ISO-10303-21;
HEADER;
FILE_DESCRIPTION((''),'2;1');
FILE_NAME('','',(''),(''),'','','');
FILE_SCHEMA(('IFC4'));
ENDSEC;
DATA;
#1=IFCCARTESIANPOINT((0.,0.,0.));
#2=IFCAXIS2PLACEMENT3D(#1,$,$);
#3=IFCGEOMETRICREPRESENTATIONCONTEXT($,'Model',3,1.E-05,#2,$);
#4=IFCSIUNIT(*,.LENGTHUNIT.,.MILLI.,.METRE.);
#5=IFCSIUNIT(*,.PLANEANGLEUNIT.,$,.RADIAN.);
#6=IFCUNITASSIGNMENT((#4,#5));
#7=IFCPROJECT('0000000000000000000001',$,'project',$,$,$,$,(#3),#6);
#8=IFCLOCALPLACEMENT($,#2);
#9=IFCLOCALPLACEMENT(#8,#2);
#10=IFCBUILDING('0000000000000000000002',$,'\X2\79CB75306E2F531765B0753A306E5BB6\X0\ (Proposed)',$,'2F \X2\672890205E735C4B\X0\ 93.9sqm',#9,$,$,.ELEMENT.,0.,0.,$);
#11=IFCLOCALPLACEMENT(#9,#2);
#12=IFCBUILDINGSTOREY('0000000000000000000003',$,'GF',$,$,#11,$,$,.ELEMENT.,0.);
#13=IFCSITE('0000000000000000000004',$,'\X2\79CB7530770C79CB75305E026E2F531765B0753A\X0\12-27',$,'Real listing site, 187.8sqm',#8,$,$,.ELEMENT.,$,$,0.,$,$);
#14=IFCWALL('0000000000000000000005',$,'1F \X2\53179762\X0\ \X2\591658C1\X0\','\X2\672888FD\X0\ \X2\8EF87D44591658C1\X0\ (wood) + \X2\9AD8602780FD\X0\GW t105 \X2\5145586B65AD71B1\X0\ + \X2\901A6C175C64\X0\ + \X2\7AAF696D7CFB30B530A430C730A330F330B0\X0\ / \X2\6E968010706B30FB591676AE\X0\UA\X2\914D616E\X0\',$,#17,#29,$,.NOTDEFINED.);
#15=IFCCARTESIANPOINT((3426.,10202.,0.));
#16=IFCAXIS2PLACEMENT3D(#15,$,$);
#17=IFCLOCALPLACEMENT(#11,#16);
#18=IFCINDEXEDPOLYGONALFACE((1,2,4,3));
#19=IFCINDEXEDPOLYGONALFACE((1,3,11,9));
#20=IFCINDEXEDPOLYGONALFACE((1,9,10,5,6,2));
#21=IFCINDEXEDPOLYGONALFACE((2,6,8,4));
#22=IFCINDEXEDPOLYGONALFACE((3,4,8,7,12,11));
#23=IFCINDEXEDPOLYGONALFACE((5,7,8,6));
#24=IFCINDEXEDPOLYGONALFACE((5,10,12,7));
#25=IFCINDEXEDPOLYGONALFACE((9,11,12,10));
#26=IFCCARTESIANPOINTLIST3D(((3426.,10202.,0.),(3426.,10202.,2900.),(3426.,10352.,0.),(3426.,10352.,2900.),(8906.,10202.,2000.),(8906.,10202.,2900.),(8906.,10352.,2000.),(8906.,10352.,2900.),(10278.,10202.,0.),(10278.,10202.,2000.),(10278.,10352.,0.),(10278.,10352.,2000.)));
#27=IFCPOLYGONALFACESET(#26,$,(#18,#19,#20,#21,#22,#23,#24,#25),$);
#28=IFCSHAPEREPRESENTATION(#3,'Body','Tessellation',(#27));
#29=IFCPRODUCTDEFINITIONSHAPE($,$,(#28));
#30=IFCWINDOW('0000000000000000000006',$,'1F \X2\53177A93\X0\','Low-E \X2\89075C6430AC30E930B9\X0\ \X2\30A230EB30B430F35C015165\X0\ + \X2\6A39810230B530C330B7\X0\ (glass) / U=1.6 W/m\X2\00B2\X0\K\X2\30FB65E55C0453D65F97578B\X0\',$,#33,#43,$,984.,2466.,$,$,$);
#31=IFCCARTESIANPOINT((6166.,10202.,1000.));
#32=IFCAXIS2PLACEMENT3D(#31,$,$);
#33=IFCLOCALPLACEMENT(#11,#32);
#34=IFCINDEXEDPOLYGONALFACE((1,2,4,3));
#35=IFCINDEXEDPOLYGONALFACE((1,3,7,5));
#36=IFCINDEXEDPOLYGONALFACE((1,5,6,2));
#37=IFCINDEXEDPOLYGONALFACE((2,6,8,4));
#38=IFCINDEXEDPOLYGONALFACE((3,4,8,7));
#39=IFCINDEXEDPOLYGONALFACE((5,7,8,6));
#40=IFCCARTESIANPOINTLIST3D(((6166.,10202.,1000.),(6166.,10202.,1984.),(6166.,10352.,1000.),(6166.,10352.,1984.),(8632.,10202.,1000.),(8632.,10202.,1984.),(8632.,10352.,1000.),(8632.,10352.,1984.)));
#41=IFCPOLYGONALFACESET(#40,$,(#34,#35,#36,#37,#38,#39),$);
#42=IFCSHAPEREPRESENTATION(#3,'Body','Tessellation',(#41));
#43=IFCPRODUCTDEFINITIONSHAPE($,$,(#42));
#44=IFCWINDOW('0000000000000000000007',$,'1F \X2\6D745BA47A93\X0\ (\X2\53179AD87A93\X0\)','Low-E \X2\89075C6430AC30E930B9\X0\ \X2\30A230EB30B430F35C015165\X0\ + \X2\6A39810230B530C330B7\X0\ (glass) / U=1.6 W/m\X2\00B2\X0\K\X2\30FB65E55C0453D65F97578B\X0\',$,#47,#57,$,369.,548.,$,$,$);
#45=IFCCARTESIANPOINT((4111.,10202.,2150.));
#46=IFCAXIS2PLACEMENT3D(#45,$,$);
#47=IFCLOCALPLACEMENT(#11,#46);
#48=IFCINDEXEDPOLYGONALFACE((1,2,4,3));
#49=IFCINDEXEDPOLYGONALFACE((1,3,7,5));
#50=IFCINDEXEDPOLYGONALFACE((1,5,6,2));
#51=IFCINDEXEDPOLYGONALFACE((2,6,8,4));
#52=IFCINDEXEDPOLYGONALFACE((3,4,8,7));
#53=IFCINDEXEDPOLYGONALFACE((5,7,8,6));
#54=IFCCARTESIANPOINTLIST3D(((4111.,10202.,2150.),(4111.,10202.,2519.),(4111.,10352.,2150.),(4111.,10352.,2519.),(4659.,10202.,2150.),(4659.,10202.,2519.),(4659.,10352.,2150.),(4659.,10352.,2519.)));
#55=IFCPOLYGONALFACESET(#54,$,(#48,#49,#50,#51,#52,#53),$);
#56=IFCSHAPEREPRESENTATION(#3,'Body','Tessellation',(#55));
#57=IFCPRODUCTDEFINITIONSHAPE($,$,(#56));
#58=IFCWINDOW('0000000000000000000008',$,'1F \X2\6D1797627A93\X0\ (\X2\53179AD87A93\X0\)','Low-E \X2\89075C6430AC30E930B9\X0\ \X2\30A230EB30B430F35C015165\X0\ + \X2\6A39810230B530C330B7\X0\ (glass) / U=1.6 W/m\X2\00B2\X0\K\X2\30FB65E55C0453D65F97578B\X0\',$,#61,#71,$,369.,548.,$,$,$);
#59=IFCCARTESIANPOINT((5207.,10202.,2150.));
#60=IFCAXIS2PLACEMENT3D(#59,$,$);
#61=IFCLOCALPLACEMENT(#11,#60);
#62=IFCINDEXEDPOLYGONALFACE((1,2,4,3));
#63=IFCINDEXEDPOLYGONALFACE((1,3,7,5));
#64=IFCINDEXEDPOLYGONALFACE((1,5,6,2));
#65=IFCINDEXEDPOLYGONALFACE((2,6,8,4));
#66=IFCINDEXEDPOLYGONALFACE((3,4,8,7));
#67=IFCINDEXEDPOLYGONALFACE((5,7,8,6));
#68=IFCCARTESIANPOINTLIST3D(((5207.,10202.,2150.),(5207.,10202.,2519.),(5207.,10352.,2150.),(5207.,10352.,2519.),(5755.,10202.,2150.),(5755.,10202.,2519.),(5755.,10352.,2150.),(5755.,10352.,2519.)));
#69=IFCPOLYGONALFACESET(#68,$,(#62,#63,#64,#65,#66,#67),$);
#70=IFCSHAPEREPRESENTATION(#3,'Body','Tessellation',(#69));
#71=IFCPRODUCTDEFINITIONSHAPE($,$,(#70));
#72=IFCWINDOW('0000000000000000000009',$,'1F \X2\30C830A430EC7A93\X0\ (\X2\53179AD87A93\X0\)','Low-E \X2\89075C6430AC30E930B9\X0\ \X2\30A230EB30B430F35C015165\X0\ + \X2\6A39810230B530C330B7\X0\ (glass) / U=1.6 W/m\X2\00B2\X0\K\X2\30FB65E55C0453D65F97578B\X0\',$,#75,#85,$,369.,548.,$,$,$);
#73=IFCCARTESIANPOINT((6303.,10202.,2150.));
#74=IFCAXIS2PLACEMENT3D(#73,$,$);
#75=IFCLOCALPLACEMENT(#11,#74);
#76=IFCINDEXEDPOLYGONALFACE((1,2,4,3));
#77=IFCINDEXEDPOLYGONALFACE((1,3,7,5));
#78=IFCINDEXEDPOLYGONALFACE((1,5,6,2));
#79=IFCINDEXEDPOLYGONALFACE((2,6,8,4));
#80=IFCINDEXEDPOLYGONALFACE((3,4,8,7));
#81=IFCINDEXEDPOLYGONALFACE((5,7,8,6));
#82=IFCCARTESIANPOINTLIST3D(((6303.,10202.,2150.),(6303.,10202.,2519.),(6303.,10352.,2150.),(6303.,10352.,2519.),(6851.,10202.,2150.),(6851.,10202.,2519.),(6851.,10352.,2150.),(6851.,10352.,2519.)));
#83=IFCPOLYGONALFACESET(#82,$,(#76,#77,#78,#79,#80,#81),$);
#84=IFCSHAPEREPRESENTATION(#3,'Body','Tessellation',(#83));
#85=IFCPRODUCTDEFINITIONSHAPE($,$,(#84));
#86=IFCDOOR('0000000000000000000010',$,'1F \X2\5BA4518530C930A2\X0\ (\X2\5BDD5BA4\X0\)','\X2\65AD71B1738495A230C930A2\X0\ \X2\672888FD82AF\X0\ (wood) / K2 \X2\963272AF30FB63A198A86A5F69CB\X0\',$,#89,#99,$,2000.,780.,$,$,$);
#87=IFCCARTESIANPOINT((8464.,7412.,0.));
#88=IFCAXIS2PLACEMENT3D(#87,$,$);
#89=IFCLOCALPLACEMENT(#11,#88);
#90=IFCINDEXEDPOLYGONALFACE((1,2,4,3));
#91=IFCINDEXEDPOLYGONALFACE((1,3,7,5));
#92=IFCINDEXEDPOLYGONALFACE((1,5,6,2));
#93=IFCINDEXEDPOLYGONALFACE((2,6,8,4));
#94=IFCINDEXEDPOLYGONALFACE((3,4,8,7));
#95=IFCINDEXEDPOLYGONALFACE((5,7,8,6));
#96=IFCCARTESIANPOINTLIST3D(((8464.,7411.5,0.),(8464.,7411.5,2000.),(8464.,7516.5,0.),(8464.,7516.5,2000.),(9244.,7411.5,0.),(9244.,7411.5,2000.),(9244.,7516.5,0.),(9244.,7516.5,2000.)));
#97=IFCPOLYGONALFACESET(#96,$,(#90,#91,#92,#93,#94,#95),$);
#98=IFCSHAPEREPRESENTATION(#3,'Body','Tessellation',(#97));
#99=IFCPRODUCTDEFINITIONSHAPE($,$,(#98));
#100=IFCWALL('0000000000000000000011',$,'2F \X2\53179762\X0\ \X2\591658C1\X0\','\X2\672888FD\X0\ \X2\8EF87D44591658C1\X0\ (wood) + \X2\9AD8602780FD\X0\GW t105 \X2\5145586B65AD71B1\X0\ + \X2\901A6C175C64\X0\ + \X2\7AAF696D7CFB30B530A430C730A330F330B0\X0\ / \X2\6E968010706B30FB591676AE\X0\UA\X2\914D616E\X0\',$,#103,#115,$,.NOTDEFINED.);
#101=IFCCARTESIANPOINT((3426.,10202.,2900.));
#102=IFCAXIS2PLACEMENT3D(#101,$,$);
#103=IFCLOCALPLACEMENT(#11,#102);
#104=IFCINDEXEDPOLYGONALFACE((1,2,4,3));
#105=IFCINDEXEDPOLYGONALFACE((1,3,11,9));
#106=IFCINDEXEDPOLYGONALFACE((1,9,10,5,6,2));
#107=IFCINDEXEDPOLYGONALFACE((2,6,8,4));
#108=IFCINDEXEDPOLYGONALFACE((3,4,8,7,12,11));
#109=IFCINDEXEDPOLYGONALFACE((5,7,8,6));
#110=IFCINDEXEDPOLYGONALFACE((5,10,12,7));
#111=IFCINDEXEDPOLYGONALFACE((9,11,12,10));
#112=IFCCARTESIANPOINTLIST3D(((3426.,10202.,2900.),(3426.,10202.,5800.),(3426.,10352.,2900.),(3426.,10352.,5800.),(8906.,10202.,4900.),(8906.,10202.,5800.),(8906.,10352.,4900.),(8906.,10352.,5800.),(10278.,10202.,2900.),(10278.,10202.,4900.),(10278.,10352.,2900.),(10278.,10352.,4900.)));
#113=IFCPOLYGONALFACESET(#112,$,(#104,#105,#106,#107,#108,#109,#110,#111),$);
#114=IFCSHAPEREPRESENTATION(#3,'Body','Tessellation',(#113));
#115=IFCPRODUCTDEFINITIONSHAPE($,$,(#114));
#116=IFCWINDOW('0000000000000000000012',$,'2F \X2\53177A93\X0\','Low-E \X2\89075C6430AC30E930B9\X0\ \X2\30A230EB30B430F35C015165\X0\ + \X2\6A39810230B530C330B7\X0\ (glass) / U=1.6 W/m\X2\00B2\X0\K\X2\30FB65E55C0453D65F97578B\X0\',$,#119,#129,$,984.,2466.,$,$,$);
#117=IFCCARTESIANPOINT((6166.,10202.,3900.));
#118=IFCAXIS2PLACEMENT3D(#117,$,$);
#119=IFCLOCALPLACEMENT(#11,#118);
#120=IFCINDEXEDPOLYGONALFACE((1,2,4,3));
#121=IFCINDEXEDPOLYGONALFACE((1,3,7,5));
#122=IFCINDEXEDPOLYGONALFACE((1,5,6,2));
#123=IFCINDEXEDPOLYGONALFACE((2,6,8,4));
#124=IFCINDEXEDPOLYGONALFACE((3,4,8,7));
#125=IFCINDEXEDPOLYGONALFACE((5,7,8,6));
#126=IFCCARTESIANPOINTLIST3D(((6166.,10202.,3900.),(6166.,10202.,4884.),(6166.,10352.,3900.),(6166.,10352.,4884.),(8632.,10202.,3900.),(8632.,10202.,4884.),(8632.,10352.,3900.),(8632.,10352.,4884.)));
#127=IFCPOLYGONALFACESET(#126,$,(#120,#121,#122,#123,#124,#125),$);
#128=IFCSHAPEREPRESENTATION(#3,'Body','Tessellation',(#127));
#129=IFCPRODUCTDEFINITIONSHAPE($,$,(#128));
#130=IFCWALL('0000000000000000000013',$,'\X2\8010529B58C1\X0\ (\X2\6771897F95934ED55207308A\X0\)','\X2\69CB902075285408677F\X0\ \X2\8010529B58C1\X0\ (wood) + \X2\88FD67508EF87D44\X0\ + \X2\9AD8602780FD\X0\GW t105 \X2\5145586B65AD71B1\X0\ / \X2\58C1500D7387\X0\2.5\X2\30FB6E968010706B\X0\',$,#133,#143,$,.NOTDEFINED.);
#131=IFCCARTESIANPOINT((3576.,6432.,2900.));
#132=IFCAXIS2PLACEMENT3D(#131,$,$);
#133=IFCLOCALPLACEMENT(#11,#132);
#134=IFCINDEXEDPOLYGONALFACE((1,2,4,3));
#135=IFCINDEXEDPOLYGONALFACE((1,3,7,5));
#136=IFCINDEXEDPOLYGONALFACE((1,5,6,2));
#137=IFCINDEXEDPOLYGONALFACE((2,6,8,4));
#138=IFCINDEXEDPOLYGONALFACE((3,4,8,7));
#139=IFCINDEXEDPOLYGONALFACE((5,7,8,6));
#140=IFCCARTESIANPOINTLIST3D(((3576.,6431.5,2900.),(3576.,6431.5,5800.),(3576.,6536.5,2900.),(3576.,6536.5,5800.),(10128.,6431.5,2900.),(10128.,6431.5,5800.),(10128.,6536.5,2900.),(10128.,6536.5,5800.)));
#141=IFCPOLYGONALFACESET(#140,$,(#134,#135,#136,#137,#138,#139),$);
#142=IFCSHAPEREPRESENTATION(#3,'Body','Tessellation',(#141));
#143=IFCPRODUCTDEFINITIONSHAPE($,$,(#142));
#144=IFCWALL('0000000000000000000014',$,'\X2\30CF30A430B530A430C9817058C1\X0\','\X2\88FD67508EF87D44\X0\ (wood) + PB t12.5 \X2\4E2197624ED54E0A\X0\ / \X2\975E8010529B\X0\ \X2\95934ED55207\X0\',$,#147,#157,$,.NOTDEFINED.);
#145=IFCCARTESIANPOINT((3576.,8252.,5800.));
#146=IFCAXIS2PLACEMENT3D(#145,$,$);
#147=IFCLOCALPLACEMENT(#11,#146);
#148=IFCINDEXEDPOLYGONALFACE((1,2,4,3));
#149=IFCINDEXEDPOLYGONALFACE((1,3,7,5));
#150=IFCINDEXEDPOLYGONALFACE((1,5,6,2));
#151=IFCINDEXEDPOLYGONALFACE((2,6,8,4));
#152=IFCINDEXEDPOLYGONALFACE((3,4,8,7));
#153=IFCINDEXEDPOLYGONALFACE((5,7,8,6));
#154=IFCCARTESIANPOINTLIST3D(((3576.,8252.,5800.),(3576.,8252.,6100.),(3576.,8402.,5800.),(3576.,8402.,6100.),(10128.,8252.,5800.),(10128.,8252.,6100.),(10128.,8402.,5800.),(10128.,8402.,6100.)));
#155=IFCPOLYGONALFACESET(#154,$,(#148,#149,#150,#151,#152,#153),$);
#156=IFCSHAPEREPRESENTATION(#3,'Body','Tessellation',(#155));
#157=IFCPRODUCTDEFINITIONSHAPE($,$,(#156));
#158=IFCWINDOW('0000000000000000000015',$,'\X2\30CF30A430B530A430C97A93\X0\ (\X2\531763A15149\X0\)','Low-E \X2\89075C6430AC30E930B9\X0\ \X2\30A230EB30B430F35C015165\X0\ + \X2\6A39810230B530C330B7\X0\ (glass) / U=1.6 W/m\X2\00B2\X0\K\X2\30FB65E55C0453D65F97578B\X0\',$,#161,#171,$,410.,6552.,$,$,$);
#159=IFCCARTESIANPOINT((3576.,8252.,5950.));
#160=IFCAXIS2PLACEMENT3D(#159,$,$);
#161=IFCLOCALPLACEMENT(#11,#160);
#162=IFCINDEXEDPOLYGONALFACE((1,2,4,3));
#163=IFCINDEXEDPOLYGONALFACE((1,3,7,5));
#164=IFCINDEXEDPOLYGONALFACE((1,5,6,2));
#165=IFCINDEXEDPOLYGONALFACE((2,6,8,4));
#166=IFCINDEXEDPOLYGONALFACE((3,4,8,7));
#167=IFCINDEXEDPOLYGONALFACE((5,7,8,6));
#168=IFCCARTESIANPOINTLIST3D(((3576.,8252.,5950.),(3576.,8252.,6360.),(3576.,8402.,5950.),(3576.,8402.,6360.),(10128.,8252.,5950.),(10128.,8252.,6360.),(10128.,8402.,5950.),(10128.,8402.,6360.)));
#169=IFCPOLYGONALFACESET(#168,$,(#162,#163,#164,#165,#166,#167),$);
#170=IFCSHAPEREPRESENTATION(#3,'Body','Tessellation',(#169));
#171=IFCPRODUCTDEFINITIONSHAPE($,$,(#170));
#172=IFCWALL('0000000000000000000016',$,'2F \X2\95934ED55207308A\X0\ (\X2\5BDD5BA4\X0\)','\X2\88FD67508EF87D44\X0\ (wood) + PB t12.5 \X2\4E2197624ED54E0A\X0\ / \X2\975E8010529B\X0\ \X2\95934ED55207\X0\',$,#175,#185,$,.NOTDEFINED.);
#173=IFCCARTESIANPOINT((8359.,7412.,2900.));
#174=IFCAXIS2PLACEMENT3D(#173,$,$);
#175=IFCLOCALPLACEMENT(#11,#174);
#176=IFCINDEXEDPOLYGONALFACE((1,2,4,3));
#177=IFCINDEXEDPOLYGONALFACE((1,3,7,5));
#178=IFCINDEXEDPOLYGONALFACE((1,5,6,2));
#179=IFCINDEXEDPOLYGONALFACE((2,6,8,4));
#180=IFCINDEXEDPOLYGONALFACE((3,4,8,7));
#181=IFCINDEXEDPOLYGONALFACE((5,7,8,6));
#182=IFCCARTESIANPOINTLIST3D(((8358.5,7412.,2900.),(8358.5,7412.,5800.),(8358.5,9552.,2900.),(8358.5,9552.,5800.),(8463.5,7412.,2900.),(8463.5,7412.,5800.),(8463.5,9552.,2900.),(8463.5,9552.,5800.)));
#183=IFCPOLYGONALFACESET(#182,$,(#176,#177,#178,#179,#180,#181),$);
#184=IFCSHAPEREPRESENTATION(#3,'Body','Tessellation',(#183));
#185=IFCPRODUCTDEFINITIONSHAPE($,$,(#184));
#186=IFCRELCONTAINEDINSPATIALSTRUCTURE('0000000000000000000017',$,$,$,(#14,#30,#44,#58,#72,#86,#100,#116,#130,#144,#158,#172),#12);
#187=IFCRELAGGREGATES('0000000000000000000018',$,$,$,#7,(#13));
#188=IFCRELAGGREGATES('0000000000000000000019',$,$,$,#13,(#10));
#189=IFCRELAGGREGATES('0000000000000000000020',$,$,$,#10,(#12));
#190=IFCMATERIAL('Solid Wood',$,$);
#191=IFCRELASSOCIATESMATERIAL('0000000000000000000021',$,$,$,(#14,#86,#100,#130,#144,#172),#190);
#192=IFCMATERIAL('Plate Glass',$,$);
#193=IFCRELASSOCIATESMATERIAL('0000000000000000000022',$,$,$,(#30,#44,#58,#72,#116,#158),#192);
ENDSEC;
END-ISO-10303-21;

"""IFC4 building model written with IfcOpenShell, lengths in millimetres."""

from ifc_helpers import new_model, si_unit, frame, frame_2d, origin, place, context, project, spatial, rectangle, extrude, material, element, fill, save


model = new_model("IFC4")

# Units and contexts
model_context = context("Model", 3, precision=1e-05, world=origin())
ifc_project = project(units=[si_unit("LENGTHUNIT", "METRE", prefix="MILLI"), si_unit("PLANEANGLEUNIT", "RADIAN")], contexts=[model_context])

# Site, building, storey
site_placement = place(None, origin())
site = spatial("IfcSite", under=ifc_project, at=site_placement, Name="秋田県秋田市港北新町12-27", ObjectType="Real listing site, 187.8sqm", CompositionType="ELEMENT", RefElevation=0.0)
building_placement = place(site_placement, origin())
building = spatial("IfcBuilding", under=site, at=building_placement, Name="秋田港北新町の家 (Proposed)", ObjectType="2F 木造平屋 93.9sqm", CompositionType="ELEMENT", ElevationOfRefHeight=0.0, ElevationOfTerrain=0.0)
storey_placement = place(building_placement, origin())
storey = spatial("IfcBuildingStorey", under=building, at=storey_placement, Name="GF", CompositionType="ELEMENT", Elevation=0.0)

# Wall, openings, windows
ifc_material_1 = material(Name="Solid Wood")
wall_1_placement = place(storey_placement, frame((3426.0, 10202.0, 0.0)))
wall_1 = element("IfcWall", 1, at=wall_1_placement, inside=storey, material=ifc_material_1, Name="1F 北面 外壁", Description="木製 軸組外壁 (wood) + 高性能GW t105 充填断熱 + 通気層 + 窯業系サイディング / 準耐火・外皮UA配慮", PredefinedType="NOTDEFINED", context=model_context, shape_type="SweptSolid", body=[
    extrude(rectangle(XDim=6852.0, YDim=150.0, at=frame_2d((3426.0, 75.0))), frame((3426.0, 10202.0, 0.0)), (0.0, 0.0, 1.0), 2900.0),
])
opening_1_placement = place(storey_placement, frame((6166.0, 10202.0, 1000.0)))
opening_1 = element("IfcOpeningElement", 2, at=opening_1_placement, cuts=wall_1, PredefinedType="NOTDEFINED", context=model_context, shape_type="SweptSolid", body=[
    extrude(rectangle(XDim=2466.0, YDim=150.0, at=frame_2d((1233.0, 75.0))), frame((6166.0, 10202.0, 1000.0)), (0.0, 0.0, 1.0), 984.0),
])
opening_2_placement = place(storey_placement, frame((4111.0, 10202.0, 2150.0)))
opening_2 = element("IfcOpeningElement", 3, at=opening_2_placement, cuts=wall_1, PredefinedType="NOTDEFINED", context=model_context, shape_type="SweptSolid", body=[
    extrude(rectangle(XDim=548.0, YDim=150.0, at=frame_2d((274.0, 75.0))), frame((4111.0, 10202.0, 2150.0)), (0.0, 0.0, 1.0), 369.0),
])
opening_3_placement = place(storey_placement, frame((5207.0, 10202.0, 2150.0)))
opening_3 = element("IfcOpeningElement", 4, at=opening_3_placement, cuts=wall_1, PredefinedType="NOTDEFINED", context=model_context, shape_type="SweptSolid", body=[
    extrude(rectangle(XDim=548.0, YDim=150.0, at=frame_2d((274.0, 75.0))), frame((5207.0, 10202.0, 2150.0)), (0.0, 0.0, 1.0), 369.0),
])
opening_4_placement = place(storey_placement, frame((6303.0, 10202.0, 2150.0)))
opening_4 = element("IfcOpeningElement", 5, at=opening_4_placement, cuts=wall_1, PredefinedType="NOTDEFINED", context=model_context, shape_type="SweptSolid", body=[
    extrude(rectangle(XDim=548.0, YDim=150.0, at=frame_2d((274.0, 75.0))), frame((6303.0, 10202.0, 2150.0)), (0.0, 0.0, 1.0), 369.0),
])
ifc_material_2 = material(Name="Plate Glass")
window_1_placement = place(storey_placement, frame((6166.0, 10202.0, 1000.0)))
window_1 = element("IfcWindow", 6, at=window_1_placement, inside=storey, material=ifc_material_2, Name="1F 北窓", Description="Low-E 複層ガラス アルゴン封入 + 樹脂サッシ (glass) / U=1.6 W/m²K・日射取得型", OverallHeight=984.0, OverallWidth=2466.0, context=model_context, shape_type="SweptSolid", body=[
    extrude(rectangle(XDim=2466.0, YDim=150.0, at=frame_2d((1233.0, 75.0))), frame((6166.0, 10202.0, 1000.0)), (0.0, 0.0, 1.0), 984.0),
])
fill(opening_1, window_1)
window_2_placement = place(storey_placement, frame((4111.0, 10202.0, 2150.0)))
window_2 = element("IfcWindow", 7, at=window_2_placement, inside=storey, material=ifc_material_2, Name="1F 浴室窓 (北高窓)", Description="Low-E 複層ガラス アルゴン封入 + 樹脂サッシ (glass) / U=1.6 W/m²K・日射取得型", OverallHeight=369.0, OverallWidth=548.0, context=model_context, shape_type="SweptSolid", body=[
    extrude(rectangle(XDim=548.0, YDim=150.0, at=frame_2d((274.0, 75.0))), frame((4111.0, 10202.0, 2150.0)), (0.0, 0.0, 1.0), 369.0),
])
fill(opening_2, window_2)
window_3_placement = place(storey_placement, frame((5207.0, 10202.0, 2150.0)))
window_3 = element("IfcWindow", 8, at=window_3_placement, inside=storey, material=ifc_material_2, Name="1F 洗面窓 (北高窓)", Description="Low-E 複層ガラス アルゴン封入 + 樹脂サッシ (glass) / U=1.6 W/m²K・日射取得型", OverallHeight=369.0, OverallWidth=548.0, context=model_context, shape_type="SweptSolid", body=[
    extrude(rectangle(XDim=548.0, YDim=150.0, at=frame_2d((274.0, 75.0))), frame((5207.0, 10202.0, 2150.0)), (0.0, 0.0, 1.0), 369.0),
])
fill(opening_3, window_3)
window_4_placement = place(storey_placement, frame((6303.0, 10202.0, 2150.0)))
window_4 = element("IfcWindow", 9, at=window_4_placement, inside=storey, material=ifc_material_2, Name="1F トイレ窓 (北高窓)", Description="Low-E 複層ガラス アルゴン封入 + 樹脂サッシ (glass) / U=1.6 W/m²K・日射取得型", OverallHeight=369.0, OverallWidth=548.0, context=model_context, shape_type="SweptSolid", body=[
    extrude(rectangle(XDim=548.0, YDim=150.0, at=frame_2d((274.0, 75.0))), frame((6303.0, 10202.0, 2150.0)), (0.0, 0.0, 1.0), 369.0),
])
fill(opening_4, window_4)

# Door
door_1_placement = place(storey_placement, frame((8464.0, 7412.0, 0.0)))
element("IfcDoor", 10, at=door_1_placement, inside=storey, material=ifc_material_1, Name="1F 室内ドア (寝室)", Description="断熱玄関ドア 木製芯 (wood) / K2 防犯・採風機構", OverallHeight=2000.0, OverallWidth=780.0, context=model_context, shape_type="SweptSolid", body=[
    extrude(rectangle(XDim=780.0, YDim=105.0, at=frame_2d((390.0, 52.0))), frame((8464.0, 7412.0, 0.0)), (0.0, 0.0, 1.0), 2000.0),
])

# Wall, opening, window
wall_2_placement = place(storey_placement, frame((3426.0, 10202.0, 2900.0)))
wall_2 = element("IfcWall", 11, at=wall_2_placement, inside=storey, material=ifc_material_1, Name="2F 北面 外壁", Description="木製 軸組外壁 (wood) + 高性能GW t105 充填断熱 + 通気層 + 窯業系サイディング / 準耐火・外皮UA配慮", PredefinedType="NOTDEFINED", context=model_context, shape_type="SweptSolid", body=[
    extrude(rectangle(XDim=6852.0, YDim=150.0, at=frame_2d((3426.0, 75.0))), frame((3426.0, 10202.0, 2900.0)), (0.0, 0.0, 1.0), 2900.0),
])
opening_5_placement = place(storey_placement, frame((6166.0, 10202.0, 3900.0)))
opening_5 = element("IfcOpeningElement", 12, at=opening_5_placement, cuts=wall_2, PredefinedType="NOTDEFINED", context=model_context, shape_type="SweptSolid", body=[
    extrude(rectangle(XDim=2466.0, YDim=150.0, at=frame_2d((1233.0, 75.0))), frame((6166.0, 10202.0, 3900.0)), (0.0, 0.0, 1.0), 984.0),
])
window_5_placement = place(storey_placement, frame((6166.0, 10202.0, 3900.0)))
window_5 = element("IfcWindow", 13, at=window_5_placement, inside=storey, material=ifc_material_2, Name="2F 北窓", Description="Low-E 複層ガラス アルゴン封入 + 樹脂サッシ (glass) / U=1.6 W/m²K・日射取得型", OverallHeight=984.0, OverallWidth=2466.0, context=model_context, shape_type="SweptSolid", body=[
    extrude(rectangle(XDim=2466.0, YDim=150.0, at=frame_2d((1233.0, 75.0))), frame((6166.0, 10202.0, 3900.0)), (0.0, 0.0, 1.0), 984.0),
])
fill(opening_5, window_5)

# Wall
wall_3_placement = place(storey_placement, frame((3576.0, 6432.0, 2900.0)))
element("IfcWall", 14, at=wall_3_placement, inside=storey, material=ifc_material_1, Name="耐力壁 (東西間仕切り)", Description="構造用合板 耐力壁 (wood) + 製材軸組 + 高性能GW t105 充填断熱 / 壁倍率2.5・準耐火", PredefinedType="NOTDEFINED", context=model_context, shape_type="SweptSolid", body=[
    extrude(rectangle(XDim=6552.0, YDim=105.0, at=frame_2d((3276.0, 52.0))), frame((3576.0, 6432.0, 2900.0)), (0.0, 0.0, 1.0), 2900.0),
])

# Wall, opening, window
wall_4_placement = place(storey_placement, frame((3576.0, 8252.0, 5800.0)))
wall_4 = element("IfcWall", 15, at=wall_4_placement, inside=storey, material=ifc_material_1, Name="ハイサイド腰壁", Description="製材軸組 (wood) + PB t12.5 両面仕上 / 非耐力 間仕切", PredefinedType="NOTDEFINED", context=model_context, shape_type="SweptSolid", body=[
    extrude(rectangle(XDim=6552.0, YDim=150.0, at=frame_2d((3276.0, 75.0))), frame((3576.0, 8252.0, 5800.0)), (0.0, 0.0, 1.0), 700.0),
])
opening_6_placement = place(storey_placement, frame((3576.0, 8252.0, 5950.0)))
opening_6 = element("IfcOpeningElement", 16, at=opening_6_placement, cuts=wall_4, PredefinedType="NOTDEFINED", context=model_context, shape_type="SweptSolid", body=[
    extrude(rectangle(XDim=6552.0, YDim=150.0, at=frame_2d((3276.0, 75.0))), frame((3576.0, 8252.0, 5950.0)), (0.0, 0.0, 1.0), 410.0),
])
window_6_placement = place(storey_placement, frame((3576.0, 8252.0, 5950.0)))
window_6 = element("IfcWindow", 17, at=window_6_placement, inside=storey, material=ifc_material_2, Name="ハイサイド窓 (北採光)", Description="Low-E 複層ガラス アルゴン封入 + 樹脂サッシ (glass) / U=1.6 W/m²K・日射取得型", OverallHeight=410.0, OverallWidth=6552.0, context=model_context, shape_type="SweptSolid", body=[
    extrude(rectangle(XDim=6552.0, YDim=150.0, at=frame_2d((3276.0, 75.0))), frame((3576.0, 8252.0, 5950.0)), (0.0, 0.0, 1.0), 410.0),
])
fill(opening_6, window_6)

# Wall
wall_5_placement = place(storey_placement, frame((8359.0, 7412.0, 2900.0)))
element("IfcWall", 18, at=wall_5_placement, inside=storey, material=ifc_material_1, Name="2F 間仕切り (寝室)", Description="製材軸組 (wood) + PB t12.5 両面仕上 / 非耐力 間仕切", PredefinedType="NOTDEFINED", context=model_context, shape_type="SweptSolid", body=[
    extrude(rectangle(XDim=105.0, YDim=2140.0, at=frame_2d((52.0, 1070.0))), frame((8359.0, 7412.0, 2900.0)), (0.0, 0.0, 1.0), 2900.0),
])

save(model, "model.ifc")
